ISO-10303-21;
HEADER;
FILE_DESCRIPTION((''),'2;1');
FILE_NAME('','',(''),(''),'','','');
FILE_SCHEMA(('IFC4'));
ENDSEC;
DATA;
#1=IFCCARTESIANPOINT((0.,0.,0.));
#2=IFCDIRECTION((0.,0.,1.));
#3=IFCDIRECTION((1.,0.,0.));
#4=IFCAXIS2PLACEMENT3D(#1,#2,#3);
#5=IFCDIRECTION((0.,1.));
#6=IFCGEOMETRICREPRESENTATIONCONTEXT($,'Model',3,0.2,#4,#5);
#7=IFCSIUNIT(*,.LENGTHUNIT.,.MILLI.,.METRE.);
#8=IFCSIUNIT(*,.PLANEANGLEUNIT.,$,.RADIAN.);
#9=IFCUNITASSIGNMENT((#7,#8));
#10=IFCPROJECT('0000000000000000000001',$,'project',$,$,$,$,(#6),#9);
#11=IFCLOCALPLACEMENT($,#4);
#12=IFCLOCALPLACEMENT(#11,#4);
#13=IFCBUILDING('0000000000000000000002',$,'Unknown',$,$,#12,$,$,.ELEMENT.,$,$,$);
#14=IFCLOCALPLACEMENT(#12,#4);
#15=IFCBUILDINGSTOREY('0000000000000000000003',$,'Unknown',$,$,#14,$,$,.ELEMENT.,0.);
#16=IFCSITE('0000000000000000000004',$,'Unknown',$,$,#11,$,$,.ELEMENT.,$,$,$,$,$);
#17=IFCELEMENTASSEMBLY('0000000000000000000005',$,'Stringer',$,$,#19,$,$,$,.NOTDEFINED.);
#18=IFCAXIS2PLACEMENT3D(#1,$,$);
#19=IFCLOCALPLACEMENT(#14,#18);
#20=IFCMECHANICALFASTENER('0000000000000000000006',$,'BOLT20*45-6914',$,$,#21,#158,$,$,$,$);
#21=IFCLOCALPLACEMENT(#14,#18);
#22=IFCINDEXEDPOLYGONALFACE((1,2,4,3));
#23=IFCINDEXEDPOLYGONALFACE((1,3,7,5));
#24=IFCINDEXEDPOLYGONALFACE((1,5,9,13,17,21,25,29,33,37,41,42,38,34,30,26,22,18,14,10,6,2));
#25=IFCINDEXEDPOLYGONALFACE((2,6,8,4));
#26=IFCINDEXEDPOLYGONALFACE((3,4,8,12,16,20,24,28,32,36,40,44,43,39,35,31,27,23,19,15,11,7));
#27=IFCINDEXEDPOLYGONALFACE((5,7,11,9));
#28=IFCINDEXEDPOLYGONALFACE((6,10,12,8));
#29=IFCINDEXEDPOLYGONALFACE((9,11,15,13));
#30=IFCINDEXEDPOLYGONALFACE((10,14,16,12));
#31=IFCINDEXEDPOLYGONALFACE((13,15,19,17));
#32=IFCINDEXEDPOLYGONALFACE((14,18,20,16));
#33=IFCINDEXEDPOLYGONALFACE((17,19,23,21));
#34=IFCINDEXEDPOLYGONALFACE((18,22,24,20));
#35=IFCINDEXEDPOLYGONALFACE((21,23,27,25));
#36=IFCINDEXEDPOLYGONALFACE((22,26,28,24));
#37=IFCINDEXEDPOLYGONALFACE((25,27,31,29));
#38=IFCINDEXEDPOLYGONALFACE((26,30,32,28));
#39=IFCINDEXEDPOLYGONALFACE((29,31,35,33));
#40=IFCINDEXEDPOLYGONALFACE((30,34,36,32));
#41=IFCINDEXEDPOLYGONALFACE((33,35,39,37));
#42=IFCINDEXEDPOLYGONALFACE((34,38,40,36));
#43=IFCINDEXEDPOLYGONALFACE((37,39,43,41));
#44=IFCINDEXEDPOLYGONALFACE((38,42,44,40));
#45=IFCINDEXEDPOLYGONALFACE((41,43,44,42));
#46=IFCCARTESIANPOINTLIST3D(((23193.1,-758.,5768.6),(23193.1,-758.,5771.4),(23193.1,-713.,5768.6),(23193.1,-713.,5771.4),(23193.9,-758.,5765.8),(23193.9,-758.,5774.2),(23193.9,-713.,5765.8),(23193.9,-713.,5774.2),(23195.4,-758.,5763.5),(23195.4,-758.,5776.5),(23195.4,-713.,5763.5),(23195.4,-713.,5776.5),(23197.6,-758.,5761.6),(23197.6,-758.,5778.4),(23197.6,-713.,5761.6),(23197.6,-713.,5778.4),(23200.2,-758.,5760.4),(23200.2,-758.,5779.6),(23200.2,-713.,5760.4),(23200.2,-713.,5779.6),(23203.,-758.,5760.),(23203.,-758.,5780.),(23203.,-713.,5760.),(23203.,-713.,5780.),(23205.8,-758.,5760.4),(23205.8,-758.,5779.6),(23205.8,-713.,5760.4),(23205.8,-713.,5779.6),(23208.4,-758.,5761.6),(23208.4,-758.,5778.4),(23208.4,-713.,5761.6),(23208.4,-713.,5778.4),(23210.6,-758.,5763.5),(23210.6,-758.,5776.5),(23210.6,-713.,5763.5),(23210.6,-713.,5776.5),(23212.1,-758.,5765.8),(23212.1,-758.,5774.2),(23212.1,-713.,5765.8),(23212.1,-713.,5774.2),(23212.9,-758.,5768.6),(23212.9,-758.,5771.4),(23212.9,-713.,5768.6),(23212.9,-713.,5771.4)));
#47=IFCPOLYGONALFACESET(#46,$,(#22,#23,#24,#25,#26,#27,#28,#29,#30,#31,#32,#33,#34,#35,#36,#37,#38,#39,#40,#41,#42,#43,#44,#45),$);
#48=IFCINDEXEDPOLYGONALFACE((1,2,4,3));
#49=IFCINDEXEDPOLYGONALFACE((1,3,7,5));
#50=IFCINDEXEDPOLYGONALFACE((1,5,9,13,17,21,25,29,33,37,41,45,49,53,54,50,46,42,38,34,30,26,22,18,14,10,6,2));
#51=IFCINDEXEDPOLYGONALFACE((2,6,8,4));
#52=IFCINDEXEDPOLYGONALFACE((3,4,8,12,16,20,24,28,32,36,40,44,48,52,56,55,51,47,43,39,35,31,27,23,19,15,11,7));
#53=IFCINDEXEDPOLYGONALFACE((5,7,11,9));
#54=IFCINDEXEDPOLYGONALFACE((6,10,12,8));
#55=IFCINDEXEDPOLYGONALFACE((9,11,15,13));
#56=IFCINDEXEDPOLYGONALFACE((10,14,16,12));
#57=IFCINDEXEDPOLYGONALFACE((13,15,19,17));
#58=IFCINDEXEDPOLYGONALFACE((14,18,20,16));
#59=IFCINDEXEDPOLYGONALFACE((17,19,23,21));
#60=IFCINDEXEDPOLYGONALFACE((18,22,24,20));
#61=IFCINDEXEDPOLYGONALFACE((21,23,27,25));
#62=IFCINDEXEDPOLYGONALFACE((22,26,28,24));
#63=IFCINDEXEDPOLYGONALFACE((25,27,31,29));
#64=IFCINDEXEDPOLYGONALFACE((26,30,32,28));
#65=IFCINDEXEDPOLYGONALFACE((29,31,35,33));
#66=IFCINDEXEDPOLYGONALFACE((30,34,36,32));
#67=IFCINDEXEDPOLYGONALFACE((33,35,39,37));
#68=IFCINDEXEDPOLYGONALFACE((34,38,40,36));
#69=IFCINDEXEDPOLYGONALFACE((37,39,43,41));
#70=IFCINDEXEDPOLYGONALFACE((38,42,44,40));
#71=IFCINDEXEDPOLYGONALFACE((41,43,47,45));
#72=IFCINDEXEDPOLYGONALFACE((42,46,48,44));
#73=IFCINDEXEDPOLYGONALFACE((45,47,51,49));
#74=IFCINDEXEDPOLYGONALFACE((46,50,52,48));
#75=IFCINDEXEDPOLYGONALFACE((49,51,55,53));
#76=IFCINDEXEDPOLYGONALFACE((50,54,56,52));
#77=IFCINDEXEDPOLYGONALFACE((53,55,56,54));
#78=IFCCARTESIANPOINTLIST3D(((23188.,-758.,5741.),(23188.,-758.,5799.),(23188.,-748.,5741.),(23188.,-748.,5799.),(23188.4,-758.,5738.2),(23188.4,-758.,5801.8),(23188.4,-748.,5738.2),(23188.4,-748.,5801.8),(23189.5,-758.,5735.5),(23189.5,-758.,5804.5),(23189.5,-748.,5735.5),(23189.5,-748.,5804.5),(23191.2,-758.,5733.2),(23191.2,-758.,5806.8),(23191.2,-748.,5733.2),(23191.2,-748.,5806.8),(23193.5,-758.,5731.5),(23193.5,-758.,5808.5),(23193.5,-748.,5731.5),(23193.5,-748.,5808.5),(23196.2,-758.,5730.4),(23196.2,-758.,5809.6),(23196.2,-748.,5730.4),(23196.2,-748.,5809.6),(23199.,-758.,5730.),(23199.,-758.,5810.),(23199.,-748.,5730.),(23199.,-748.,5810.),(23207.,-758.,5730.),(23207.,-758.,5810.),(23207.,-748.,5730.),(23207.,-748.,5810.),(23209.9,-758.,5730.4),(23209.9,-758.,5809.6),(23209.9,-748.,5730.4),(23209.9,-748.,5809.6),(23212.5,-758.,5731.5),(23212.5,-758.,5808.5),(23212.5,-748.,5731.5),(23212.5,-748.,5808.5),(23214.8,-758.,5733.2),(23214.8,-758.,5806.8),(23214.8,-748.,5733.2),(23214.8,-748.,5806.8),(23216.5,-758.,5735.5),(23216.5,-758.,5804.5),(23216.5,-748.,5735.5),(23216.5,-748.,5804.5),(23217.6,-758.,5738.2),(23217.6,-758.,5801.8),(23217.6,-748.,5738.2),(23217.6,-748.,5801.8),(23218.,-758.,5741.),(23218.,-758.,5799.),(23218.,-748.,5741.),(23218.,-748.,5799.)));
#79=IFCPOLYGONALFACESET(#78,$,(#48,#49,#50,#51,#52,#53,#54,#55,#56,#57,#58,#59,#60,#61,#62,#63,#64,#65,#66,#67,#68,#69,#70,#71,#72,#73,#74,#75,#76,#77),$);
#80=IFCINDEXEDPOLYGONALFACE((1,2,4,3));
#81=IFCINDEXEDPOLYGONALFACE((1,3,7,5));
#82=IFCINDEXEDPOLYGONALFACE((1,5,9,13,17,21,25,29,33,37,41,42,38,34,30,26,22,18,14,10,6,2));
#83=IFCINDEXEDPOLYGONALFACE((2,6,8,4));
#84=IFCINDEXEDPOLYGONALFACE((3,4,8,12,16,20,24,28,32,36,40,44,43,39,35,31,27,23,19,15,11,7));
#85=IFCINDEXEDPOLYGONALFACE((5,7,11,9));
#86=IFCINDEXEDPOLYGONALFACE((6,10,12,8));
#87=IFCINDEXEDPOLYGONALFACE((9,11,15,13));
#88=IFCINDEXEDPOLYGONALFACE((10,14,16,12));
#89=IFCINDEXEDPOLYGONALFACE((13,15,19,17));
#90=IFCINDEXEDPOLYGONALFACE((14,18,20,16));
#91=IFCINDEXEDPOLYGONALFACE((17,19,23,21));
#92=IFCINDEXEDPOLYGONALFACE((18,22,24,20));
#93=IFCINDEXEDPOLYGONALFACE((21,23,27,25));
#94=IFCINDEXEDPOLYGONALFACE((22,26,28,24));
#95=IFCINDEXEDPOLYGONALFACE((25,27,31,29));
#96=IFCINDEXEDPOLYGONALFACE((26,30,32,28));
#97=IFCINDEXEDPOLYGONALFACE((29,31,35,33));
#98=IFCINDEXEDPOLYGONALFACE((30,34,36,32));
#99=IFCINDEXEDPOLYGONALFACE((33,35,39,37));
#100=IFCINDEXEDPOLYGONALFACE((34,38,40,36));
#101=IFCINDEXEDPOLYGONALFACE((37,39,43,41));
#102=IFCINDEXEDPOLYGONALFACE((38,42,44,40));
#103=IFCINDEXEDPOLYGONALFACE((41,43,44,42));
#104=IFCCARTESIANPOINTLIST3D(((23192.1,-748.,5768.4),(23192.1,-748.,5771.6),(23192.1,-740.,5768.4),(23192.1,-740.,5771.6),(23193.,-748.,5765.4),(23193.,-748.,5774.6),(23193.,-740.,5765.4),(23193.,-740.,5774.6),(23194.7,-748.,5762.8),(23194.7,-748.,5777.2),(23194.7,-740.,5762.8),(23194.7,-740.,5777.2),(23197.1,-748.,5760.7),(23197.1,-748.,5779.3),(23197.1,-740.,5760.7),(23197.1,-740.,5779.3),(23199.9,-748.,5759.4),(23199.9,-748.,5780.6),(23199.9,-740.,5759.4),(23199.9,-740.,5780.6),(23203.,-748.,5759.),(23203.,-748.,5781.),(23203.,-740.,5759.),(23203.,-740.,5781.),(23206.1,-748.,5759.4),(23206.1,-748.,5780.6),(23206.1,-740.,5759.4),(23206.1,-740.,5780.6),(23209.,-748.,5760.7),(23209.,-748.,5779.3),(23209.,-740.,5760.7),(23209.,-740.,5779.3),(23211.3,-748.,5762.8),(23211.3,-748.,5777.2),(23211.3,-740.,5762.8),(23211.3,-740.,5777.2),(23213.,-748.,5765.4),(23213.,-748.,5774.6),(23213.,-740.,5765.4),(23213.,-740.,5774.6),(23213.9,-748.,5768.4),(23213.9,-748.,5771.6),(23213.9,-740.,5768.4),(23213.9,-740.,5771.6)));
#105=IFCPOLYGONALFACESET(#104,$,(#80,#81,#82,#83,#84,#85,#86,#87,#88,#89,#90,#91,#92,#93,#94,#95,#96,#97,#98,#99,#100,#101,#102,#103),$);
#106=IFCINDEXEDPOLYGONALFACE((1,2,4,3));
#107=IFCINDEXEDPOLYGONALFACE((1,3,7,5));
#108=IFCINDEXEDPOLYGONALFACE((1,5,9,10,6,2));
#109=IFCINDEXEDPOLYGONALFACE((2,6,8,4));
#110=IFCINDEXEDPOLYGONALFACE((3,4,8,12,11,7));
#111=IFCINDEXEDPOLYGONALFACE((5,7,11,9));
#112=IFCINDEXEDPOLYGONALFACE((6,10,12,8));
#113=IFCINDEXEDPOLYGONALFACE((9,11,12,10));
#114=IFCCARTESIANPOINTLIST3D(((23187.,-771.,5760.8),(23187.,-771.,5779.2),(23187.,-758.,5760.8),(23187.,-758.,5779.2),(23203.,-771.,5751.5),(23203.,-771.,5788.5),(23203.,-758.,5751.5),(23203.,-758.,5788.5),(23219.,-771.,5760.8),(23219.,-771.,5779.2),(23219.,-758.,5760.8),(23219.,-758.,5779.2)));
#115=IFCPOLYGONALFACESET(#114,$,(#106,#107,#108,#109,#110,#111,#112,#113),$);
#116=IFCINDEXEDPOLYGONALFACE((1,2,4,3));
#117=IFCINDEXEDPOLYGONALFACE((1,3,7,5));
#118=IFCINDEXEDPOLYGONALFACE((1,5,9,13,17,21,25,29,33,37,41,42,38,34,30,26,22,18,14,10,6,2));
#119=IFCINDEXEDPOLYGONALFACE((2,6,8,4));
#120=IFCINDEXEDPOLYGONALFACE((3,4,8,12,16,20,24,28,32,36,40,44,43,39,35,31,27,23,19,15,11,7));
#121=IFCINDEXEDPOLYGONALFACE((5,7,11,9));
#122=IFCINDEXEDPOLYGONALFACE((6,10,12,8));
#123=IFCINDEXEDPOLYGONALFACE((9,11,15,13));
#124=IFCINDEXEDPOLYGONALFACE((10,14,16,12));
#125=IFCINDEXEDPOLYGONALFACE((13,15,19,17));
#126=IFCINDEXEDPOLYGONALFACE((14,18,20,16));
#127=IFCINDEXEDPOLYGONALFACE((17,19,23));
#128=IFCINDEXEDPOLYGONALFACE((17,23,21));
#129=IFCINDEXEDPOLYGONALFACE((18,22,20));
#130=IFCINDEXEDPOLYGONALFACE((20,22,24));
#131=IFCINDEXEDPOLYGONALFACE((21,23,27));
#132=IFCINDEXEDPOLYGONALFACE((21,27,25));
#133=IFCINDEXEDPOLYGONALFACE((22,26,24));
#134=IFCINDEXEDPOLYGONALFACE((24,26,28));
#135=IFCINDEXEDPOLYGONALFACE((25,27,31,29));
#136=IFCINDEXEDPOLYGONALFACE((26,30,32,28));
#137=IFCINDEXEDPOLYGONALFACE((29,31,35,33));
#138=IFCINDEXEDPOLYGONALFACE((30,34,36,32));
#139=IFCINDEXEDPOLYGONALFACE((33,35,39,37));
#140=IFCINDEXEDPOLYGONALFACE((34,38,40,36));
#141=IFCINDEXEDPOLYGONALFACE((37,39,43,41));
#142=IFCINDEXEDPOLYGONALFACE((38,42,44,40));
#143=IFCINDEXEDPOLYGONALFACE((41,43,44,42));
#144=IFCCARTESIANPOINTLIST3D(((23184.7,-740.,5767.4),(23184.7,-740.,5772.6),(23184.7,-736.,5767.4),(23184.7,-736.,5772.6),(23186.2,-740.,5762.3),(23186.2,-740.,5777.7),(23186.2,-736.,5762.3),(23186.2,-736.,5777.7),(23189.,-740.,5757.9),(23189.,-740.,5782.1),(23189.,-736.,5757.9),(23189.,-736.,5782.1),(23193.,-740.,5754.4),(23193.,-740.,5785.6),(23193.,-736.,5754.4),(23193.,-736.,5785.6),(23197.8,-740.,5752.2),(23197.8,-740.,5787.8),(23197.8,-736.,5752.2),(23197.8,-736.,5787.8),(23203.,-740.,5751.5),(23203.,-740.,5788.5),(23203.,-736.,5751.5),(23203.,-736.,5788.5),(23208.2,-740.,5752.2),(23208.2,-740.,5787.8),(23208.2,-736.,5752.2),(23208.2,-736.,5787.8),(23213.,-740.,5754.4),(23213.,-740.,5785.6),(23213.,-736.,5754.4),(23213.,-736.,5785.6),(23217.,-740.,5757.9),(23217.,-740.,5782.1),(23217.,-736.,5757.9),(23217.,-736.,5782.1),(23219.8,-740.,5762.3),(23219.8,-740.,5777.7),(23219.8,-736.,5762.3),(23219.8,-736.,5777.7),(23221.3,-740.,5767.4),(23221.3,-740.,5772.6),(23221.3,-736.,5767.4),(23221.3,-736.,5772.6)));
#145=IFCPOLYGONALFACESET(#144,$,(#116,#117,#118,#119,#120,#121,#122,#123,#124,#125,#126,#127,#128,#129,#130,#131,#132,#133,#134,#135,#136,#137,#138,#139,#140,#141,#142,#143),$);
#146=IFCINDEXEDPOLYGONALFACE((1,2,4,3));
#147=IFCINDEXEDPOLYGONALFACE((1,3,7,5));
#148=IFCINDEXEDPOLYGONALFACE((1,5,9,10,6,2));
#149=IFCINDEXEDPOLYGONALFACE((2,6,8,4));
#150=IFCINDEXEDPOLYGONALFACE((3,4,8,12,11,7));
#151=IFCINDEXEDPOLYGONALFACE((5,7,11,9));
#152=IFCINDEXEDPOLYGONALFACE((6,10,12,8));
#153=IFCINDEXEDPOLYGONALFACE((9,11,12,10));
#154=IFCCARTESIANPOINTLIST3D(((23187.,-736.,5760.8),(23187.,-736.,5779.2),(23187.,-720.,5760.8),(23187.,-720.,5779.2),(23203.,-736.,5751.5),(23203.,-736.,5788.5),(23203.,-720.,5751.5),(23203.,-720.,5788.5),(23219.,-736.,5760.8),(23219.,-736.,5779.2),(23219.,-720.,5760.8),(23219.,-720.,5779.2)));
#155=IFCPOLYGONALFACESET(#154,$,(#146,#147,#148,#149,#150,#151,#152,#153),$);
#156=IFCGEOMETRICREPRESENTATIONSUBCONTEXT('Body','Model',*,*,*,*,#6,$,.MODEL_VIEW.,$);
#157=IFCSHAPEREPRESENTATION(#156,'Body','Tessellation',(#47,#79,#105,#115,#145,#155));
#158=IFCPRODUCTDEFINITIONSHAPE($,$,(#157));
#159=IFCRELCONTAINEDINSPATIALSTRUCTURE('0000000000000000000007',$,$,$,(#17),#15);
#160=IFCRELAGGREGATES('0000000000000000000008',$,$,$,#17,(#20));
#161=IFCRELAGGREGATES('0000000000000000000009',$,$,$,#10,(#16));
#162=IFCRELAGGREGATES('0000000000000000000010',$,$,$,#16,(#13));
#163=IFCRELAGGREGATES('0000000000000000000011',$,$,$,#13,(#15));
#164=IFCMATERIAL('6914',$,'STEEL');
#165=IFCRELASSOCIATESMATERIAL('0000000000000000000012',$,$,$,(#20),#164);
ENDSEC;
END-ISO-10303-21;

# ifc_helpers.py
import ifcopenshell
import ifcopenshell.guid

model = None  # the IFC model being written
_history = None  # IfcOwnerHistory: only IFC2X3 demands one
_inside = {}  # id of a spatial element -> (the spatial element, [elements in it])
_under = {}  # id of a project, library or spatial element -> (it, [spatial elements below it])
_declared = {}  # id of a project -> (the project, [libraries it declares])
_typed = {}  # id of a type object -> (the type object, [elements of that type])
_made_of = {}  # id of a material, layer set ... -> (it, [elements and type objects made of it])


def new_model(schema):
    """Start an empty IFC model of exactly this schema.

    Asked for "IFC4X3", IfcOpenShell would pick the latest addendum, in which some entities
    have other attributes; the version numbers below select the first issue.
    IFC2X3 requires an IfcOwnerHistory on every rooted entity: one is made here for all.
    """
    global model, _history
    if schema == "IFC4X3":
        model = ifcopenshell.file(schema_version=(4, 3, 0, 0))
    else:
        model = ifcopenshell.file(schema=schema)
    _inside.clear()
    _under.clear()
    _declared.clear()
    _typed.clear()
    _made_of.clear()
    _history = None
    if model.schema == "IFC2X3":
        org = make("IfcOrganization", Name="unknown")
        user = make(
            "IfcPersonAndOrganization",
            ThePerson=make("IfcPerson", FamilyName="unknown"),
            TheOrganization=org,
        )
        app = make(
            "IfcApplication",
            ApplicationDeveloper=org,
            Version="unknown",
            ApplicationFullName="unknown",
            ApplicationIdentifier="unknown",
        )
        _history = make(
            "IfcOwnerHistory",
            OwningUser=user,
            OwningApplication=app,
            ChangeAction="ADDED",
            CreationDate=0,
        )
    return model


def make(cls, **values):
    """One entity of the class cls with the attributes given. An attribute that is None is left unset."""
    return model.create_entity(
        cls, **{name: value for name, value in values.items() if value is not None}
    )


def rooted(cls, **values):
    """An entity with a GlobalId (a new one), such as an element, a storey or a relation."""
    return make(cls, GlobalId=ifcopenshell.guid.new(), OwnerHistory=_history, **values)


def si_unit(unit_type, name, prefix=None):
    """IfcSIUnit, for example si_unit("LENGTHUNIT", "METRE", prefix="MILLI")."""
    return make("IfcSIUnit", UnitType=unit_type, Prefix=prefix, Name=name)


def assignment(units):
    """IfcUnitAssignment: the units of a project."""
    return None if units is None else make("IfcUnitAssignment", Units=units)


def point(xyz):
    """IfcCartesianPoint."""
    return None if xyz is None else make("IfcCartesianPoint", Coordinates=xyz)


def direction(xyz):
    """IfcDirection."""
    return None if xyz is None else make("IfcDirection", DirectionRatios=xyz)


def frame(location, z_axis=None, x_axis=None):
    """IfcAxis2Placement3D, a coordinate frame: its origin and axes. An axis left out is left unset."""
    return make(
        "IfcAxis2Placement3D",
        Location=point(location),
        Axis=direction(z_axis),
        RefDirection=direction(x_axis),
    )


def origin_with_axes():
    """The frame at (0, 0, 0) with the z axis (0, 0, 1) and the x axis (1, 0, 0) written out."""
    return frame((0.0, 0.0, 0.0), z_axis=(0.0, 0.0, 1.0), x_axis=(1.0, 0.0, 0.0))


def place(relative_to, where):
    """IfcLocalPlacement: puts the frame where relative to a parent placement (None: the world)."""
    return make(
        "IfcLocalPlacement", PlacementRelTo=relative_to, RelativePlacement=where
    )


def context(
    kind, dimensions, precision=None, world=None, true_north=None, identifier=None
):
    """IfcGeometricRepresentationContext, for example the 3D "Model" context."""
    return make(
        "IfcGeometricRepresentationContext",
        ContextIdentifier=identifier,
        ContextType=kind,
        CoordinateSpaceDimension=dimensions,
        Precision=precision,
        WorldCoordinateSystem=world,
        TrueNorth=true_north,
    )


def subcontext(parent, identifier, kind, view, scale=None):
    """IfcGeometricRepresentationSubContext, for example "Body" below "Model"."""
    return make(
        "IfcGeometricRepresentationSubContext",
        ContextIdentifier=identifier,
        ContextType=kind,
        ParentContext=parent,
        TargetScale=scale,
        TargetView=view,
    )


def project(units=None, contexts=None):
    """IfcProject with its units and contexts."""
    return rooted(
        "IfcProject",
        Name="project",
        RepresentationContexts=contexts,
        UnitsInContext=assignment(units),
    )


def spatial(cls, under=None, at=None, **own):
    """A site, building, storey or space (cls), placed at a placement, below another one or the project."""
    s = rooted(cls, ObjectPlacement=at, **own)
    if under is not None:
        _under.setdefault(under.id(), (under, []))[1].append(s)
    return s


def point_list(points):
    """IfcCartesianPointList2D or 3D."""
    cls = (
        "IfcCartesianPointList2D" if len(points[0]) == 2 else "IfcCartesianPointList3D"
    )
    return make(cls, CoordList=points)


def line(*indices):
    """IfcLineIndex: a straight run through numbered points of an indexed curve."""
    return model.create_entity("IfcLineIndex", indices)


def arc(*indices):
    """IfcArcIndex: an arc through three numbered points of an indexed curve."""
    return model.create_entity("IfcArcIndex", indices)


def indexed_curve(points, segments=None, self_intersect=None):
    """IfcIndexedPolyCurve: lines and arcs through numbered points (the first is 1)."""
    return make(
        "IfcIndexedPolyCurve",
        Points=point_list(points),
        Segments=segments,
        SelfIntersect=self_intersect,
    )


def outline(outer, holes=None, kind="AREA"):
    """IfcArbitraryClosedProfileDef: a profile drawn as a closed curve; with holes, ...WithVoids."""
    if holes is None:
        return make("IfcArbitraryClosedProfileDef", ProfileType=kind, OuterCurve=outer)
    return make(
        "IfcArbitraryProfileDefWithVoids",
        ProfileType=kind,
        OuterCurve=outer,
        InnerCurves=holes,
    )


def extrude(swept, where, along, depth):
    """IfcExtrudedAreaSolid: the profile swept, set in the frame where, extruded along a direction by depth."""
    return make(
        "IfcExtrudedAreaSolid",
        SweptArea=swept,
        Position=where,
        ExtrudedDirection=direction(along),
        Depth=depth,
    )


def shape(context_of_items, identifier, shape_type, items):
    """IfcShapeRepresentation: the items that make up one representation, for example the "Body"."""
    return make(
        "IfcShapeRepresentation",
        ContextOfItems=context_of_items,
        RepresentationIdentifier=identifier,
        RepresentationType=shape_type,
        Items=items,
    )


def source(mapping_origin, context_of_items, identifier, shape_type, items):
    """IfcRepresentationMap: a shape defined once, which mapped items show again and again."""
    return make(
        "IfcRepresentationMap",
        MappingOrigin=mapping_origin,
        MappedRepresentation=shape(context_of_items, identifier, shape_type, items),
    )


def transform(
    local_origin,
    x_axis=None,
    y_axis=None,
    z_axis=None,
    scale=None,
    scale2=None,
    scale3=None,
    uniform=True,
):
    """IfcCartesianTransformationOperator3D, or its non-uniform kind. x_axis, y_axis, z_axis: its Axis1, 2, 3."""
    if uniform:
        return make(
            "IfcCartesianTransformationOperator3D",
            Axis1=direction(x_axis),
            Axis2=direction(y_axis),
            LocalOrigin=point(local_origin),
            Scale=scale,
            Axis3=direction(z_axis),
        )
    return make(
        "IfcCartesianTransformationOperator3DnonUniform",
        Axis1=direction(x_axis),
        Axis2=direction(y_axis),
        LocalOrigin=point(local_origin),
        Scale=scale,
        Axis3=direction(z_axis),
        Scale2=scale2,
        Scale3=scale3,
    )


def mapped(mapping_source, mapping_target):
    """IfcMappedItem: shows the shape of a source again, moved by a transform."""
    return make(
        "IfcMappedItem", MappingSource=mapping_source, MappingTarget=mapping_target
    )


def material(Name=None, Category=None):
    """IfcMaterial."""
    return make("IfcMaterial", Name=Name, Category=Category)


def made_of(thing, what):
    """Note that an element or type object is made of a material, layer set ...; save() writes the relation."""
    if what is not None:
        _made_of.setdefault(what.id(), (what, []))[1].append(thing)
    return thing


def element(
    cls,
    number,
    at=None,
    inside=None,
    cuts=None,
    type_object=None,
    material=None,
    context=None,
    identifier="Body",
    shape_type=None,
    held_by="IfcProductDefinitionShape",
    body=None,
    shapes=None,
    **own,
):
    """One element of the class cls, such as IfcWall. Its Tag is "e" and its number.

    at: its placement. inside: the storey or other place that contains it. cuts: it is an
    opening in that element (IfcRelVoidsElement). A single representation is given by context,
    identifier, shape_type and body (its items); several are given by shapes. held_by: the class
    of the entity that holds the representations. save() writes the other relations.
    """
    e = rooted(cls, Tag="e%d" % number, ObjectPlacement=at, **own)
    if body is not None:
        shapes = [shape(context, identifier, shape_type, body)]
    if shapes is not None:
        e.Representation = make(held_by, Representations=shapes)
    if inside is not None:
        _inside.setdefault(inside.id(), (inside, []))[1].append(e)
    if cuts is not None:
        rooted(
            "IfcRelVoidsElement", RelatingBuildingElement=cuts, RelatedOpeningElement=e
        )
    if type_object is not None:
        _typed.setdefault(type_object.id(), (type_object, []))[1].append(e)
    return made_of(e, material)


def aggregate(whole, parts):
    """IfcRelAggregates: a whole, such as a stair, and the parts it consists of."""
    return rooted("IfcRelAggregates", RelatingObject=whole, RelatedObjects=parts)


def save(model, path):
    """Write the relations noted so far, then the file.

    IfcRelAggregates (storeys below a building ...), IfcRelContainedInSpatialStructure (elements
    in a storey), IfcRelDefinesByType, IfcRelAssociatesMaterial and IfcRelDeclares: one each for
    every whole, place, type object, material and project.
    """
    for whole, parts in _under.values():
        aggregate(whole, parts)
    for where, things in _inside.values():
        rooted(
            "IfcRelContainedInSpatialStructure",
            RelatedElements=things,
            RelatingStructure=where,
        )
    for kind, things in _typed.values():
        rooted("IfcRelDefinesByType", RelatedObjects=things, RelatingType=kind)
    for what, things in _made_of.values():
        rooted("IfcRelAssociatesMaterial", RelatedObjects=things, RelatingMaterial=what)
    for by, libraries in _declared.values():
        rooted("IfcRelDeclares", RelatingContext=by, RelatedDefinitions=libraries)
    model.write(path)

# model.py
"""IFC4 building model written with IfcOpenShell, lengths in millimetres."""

from ifc_helpers import new_model, si_unit, direction, frame, origin_with_axes, place, context, subcontext, project, spatial, line, arc, indexed_curve, outline, extrude, source, transform, mapped, material, element, aggregate, save


model = new_model("IFC4")

# Units and contexts
model_context = context("Model", 3, precision=0.2, world=origin_with_axes(), true_north=direction((0.0, 1.0)))
body_context = subcontext(model_context, "Body", "Model", "MODEL_VIEW")
ifc_project = project(units=[si_unit("LENGTHUNIT", "METRE", prefix="MILLI"), si_unit("PLANEANGLEUNIT", "RADIAN")], contexts=[model_context])

# Site, building, storey
site_placement = place(None, origin_with_axes())
site = spatial("IfcSite", under=ifc_project, at=site_placement, Name="Unknown", CompositionType="ELEMENT")
building_placement = place(site_placement, origin_with_axes())
building = spatial("IfcBuilding", under=site, at=building_placement, Name="Unknown", CompositionType="ELEMENT")
storey_placement = place(building_placement, origin_with_axes())
storey = spatial("IfcBuildingStorey", under=building, at=storey_placement, Name="Unknown", CompositionType="ELEMENT", Elevation=0.0)

# Element assembly
assembly_1_placement = place(storey_placement, frame((23193.0, -780.0, 7430.0), z_axis=(0.0, -1.0, 0.000002), x_axis=(0.0, -0.000002, -1.0)))
assembly_1 = element("IfcElementAssembly", 1, at=assembly_1_placement, inside=storey, Name="Stringer", PredefinedType="NOTDEFINED")

# Mechanical fastener
ifc_material_1 = material(Name="6914", Category="STEEL")
shared_shape_1 = source(origin_with_axes(), body_context, "Body", "SweptSolid", [
    extrude(outline(indexed_curve([(10.0, 0.0), (0.0, 10.0), (-10.0, 0.0), (0.0, -10.0)], segments=[arc(1, 2, 3), arc(3, 4, 1)])), frame((0.0, 0.0, 10.0), z_axis=(0.0, -0.000002, -1.0), x_axis=(0.0, 1.0, 0.0)), (0.0, 0.0, 1.0), 45.0),
    extrude(outline(indexed_curve([(-29.0, 15.0), (29.0, 15.0), (29.0, 15.0), (36.8, 11.8), (40.0, 4.0), (40.0, -4.0), (36.8, -11.8), (29.0, -15.0), (-29.0, -15.0), (-30.0, -15.0), (-40.0, -4.0), (-40.0, 4.0), (-36.8, 11.8)], segments=[line(1, 2, 3), arc(3, 4, 5), line(5, 6), arc(6, 7, 8), line(8, 9), arc(9, 10, 11), line(11, 12), arc(12, 13, 1)])), frame((0.0, 0.0, 10.0), z_axis=(0.0, -0.000002, -1.0), x_axis=(0.0, 1.0, 0.0)), (0.0, 0.0, 1.0), 10.0),
    extrude(outline(indexed_curve([(11.0, 0.0), (0.0, 11.0), (-11.0, 0.0), (0.0, -11.0)], segments=[arc(1, 2, 3), arc(3, 4, 1)])), frame((0.0, 0.0, 0.0), z_axis=(0.0, -0.000002, -1.0), x_axis=(0.0, 1.0, 0.0)), (0.0, 0.0, 1.0), 8.0),
    extrude(outline(indexed_curve([(18.5, 0.0), (9.2, 16.0), (-9.2, 16.0), (-18.5, 0.0), (-9.2, -16.0), (9.2, -16.0)], segments=[line(1, 2, 3, 4, 5, 6, 1)])), frame((0.0, 0.0, 23.0), z_axis=(0.0, -0.000002, -1.0), x_axis=(0.0, 1.0, 0.0)), (0.0, 0.0, 1.0), 13.0),
    extrude(outline(indexed_curve([(18.5, 0.0), (0.0, 18.5), (-18.5, 0.0), (0.0, -18.5)], segments=[arc(1, 2, 3), arc(3, 4, 1)])), frame((0.0, 0.0, -8.0), z_axis=(0.0, -0.000002, -1.0), x_axis=(0.0, 1.0, 0.0)), (0.0, 0.0, 1.0), 4.0),
    extrude(outline(indexed_curve([(18.5, 0.0), (9.2, 16.0), (-9.2, 16.0), (-18.5, 0.0), (-9.2, -16.0), (9.2, -16.0)], segments=[line(1, 2, 3, 4, 5, 6, 1)])), frame((0.0, 0.0, -12.0), z_axis=(0.0, -0.000002, -1.0), x_axis=(0.0, 1.0, 0.0)), (0.0, 0.0, 1.0), 16.0),
])
mechanical_fastener_1_placement = place(assembly_1_placement, frame((1660.0, 10.0, -32.0), z_axis=(0.0, 0.0, 1.0), x_axis=(0.0, -1.0, 0.000002)))
mechanical_fastener_1 = element("IfcMechanicalFastener", 2, at=mechanical_fastener_1_placement, material=ifc_material_1, Name="BOLT20*45-6914", context=body_context, shape_type="MappedRepresentation", body=[
    mapped(shared_shape_1, transform((0.0, 0.0, 0.0))),
])
aggregate(assembly_1, [mechanical_fastener_1])

save(model, "model.ifc")
